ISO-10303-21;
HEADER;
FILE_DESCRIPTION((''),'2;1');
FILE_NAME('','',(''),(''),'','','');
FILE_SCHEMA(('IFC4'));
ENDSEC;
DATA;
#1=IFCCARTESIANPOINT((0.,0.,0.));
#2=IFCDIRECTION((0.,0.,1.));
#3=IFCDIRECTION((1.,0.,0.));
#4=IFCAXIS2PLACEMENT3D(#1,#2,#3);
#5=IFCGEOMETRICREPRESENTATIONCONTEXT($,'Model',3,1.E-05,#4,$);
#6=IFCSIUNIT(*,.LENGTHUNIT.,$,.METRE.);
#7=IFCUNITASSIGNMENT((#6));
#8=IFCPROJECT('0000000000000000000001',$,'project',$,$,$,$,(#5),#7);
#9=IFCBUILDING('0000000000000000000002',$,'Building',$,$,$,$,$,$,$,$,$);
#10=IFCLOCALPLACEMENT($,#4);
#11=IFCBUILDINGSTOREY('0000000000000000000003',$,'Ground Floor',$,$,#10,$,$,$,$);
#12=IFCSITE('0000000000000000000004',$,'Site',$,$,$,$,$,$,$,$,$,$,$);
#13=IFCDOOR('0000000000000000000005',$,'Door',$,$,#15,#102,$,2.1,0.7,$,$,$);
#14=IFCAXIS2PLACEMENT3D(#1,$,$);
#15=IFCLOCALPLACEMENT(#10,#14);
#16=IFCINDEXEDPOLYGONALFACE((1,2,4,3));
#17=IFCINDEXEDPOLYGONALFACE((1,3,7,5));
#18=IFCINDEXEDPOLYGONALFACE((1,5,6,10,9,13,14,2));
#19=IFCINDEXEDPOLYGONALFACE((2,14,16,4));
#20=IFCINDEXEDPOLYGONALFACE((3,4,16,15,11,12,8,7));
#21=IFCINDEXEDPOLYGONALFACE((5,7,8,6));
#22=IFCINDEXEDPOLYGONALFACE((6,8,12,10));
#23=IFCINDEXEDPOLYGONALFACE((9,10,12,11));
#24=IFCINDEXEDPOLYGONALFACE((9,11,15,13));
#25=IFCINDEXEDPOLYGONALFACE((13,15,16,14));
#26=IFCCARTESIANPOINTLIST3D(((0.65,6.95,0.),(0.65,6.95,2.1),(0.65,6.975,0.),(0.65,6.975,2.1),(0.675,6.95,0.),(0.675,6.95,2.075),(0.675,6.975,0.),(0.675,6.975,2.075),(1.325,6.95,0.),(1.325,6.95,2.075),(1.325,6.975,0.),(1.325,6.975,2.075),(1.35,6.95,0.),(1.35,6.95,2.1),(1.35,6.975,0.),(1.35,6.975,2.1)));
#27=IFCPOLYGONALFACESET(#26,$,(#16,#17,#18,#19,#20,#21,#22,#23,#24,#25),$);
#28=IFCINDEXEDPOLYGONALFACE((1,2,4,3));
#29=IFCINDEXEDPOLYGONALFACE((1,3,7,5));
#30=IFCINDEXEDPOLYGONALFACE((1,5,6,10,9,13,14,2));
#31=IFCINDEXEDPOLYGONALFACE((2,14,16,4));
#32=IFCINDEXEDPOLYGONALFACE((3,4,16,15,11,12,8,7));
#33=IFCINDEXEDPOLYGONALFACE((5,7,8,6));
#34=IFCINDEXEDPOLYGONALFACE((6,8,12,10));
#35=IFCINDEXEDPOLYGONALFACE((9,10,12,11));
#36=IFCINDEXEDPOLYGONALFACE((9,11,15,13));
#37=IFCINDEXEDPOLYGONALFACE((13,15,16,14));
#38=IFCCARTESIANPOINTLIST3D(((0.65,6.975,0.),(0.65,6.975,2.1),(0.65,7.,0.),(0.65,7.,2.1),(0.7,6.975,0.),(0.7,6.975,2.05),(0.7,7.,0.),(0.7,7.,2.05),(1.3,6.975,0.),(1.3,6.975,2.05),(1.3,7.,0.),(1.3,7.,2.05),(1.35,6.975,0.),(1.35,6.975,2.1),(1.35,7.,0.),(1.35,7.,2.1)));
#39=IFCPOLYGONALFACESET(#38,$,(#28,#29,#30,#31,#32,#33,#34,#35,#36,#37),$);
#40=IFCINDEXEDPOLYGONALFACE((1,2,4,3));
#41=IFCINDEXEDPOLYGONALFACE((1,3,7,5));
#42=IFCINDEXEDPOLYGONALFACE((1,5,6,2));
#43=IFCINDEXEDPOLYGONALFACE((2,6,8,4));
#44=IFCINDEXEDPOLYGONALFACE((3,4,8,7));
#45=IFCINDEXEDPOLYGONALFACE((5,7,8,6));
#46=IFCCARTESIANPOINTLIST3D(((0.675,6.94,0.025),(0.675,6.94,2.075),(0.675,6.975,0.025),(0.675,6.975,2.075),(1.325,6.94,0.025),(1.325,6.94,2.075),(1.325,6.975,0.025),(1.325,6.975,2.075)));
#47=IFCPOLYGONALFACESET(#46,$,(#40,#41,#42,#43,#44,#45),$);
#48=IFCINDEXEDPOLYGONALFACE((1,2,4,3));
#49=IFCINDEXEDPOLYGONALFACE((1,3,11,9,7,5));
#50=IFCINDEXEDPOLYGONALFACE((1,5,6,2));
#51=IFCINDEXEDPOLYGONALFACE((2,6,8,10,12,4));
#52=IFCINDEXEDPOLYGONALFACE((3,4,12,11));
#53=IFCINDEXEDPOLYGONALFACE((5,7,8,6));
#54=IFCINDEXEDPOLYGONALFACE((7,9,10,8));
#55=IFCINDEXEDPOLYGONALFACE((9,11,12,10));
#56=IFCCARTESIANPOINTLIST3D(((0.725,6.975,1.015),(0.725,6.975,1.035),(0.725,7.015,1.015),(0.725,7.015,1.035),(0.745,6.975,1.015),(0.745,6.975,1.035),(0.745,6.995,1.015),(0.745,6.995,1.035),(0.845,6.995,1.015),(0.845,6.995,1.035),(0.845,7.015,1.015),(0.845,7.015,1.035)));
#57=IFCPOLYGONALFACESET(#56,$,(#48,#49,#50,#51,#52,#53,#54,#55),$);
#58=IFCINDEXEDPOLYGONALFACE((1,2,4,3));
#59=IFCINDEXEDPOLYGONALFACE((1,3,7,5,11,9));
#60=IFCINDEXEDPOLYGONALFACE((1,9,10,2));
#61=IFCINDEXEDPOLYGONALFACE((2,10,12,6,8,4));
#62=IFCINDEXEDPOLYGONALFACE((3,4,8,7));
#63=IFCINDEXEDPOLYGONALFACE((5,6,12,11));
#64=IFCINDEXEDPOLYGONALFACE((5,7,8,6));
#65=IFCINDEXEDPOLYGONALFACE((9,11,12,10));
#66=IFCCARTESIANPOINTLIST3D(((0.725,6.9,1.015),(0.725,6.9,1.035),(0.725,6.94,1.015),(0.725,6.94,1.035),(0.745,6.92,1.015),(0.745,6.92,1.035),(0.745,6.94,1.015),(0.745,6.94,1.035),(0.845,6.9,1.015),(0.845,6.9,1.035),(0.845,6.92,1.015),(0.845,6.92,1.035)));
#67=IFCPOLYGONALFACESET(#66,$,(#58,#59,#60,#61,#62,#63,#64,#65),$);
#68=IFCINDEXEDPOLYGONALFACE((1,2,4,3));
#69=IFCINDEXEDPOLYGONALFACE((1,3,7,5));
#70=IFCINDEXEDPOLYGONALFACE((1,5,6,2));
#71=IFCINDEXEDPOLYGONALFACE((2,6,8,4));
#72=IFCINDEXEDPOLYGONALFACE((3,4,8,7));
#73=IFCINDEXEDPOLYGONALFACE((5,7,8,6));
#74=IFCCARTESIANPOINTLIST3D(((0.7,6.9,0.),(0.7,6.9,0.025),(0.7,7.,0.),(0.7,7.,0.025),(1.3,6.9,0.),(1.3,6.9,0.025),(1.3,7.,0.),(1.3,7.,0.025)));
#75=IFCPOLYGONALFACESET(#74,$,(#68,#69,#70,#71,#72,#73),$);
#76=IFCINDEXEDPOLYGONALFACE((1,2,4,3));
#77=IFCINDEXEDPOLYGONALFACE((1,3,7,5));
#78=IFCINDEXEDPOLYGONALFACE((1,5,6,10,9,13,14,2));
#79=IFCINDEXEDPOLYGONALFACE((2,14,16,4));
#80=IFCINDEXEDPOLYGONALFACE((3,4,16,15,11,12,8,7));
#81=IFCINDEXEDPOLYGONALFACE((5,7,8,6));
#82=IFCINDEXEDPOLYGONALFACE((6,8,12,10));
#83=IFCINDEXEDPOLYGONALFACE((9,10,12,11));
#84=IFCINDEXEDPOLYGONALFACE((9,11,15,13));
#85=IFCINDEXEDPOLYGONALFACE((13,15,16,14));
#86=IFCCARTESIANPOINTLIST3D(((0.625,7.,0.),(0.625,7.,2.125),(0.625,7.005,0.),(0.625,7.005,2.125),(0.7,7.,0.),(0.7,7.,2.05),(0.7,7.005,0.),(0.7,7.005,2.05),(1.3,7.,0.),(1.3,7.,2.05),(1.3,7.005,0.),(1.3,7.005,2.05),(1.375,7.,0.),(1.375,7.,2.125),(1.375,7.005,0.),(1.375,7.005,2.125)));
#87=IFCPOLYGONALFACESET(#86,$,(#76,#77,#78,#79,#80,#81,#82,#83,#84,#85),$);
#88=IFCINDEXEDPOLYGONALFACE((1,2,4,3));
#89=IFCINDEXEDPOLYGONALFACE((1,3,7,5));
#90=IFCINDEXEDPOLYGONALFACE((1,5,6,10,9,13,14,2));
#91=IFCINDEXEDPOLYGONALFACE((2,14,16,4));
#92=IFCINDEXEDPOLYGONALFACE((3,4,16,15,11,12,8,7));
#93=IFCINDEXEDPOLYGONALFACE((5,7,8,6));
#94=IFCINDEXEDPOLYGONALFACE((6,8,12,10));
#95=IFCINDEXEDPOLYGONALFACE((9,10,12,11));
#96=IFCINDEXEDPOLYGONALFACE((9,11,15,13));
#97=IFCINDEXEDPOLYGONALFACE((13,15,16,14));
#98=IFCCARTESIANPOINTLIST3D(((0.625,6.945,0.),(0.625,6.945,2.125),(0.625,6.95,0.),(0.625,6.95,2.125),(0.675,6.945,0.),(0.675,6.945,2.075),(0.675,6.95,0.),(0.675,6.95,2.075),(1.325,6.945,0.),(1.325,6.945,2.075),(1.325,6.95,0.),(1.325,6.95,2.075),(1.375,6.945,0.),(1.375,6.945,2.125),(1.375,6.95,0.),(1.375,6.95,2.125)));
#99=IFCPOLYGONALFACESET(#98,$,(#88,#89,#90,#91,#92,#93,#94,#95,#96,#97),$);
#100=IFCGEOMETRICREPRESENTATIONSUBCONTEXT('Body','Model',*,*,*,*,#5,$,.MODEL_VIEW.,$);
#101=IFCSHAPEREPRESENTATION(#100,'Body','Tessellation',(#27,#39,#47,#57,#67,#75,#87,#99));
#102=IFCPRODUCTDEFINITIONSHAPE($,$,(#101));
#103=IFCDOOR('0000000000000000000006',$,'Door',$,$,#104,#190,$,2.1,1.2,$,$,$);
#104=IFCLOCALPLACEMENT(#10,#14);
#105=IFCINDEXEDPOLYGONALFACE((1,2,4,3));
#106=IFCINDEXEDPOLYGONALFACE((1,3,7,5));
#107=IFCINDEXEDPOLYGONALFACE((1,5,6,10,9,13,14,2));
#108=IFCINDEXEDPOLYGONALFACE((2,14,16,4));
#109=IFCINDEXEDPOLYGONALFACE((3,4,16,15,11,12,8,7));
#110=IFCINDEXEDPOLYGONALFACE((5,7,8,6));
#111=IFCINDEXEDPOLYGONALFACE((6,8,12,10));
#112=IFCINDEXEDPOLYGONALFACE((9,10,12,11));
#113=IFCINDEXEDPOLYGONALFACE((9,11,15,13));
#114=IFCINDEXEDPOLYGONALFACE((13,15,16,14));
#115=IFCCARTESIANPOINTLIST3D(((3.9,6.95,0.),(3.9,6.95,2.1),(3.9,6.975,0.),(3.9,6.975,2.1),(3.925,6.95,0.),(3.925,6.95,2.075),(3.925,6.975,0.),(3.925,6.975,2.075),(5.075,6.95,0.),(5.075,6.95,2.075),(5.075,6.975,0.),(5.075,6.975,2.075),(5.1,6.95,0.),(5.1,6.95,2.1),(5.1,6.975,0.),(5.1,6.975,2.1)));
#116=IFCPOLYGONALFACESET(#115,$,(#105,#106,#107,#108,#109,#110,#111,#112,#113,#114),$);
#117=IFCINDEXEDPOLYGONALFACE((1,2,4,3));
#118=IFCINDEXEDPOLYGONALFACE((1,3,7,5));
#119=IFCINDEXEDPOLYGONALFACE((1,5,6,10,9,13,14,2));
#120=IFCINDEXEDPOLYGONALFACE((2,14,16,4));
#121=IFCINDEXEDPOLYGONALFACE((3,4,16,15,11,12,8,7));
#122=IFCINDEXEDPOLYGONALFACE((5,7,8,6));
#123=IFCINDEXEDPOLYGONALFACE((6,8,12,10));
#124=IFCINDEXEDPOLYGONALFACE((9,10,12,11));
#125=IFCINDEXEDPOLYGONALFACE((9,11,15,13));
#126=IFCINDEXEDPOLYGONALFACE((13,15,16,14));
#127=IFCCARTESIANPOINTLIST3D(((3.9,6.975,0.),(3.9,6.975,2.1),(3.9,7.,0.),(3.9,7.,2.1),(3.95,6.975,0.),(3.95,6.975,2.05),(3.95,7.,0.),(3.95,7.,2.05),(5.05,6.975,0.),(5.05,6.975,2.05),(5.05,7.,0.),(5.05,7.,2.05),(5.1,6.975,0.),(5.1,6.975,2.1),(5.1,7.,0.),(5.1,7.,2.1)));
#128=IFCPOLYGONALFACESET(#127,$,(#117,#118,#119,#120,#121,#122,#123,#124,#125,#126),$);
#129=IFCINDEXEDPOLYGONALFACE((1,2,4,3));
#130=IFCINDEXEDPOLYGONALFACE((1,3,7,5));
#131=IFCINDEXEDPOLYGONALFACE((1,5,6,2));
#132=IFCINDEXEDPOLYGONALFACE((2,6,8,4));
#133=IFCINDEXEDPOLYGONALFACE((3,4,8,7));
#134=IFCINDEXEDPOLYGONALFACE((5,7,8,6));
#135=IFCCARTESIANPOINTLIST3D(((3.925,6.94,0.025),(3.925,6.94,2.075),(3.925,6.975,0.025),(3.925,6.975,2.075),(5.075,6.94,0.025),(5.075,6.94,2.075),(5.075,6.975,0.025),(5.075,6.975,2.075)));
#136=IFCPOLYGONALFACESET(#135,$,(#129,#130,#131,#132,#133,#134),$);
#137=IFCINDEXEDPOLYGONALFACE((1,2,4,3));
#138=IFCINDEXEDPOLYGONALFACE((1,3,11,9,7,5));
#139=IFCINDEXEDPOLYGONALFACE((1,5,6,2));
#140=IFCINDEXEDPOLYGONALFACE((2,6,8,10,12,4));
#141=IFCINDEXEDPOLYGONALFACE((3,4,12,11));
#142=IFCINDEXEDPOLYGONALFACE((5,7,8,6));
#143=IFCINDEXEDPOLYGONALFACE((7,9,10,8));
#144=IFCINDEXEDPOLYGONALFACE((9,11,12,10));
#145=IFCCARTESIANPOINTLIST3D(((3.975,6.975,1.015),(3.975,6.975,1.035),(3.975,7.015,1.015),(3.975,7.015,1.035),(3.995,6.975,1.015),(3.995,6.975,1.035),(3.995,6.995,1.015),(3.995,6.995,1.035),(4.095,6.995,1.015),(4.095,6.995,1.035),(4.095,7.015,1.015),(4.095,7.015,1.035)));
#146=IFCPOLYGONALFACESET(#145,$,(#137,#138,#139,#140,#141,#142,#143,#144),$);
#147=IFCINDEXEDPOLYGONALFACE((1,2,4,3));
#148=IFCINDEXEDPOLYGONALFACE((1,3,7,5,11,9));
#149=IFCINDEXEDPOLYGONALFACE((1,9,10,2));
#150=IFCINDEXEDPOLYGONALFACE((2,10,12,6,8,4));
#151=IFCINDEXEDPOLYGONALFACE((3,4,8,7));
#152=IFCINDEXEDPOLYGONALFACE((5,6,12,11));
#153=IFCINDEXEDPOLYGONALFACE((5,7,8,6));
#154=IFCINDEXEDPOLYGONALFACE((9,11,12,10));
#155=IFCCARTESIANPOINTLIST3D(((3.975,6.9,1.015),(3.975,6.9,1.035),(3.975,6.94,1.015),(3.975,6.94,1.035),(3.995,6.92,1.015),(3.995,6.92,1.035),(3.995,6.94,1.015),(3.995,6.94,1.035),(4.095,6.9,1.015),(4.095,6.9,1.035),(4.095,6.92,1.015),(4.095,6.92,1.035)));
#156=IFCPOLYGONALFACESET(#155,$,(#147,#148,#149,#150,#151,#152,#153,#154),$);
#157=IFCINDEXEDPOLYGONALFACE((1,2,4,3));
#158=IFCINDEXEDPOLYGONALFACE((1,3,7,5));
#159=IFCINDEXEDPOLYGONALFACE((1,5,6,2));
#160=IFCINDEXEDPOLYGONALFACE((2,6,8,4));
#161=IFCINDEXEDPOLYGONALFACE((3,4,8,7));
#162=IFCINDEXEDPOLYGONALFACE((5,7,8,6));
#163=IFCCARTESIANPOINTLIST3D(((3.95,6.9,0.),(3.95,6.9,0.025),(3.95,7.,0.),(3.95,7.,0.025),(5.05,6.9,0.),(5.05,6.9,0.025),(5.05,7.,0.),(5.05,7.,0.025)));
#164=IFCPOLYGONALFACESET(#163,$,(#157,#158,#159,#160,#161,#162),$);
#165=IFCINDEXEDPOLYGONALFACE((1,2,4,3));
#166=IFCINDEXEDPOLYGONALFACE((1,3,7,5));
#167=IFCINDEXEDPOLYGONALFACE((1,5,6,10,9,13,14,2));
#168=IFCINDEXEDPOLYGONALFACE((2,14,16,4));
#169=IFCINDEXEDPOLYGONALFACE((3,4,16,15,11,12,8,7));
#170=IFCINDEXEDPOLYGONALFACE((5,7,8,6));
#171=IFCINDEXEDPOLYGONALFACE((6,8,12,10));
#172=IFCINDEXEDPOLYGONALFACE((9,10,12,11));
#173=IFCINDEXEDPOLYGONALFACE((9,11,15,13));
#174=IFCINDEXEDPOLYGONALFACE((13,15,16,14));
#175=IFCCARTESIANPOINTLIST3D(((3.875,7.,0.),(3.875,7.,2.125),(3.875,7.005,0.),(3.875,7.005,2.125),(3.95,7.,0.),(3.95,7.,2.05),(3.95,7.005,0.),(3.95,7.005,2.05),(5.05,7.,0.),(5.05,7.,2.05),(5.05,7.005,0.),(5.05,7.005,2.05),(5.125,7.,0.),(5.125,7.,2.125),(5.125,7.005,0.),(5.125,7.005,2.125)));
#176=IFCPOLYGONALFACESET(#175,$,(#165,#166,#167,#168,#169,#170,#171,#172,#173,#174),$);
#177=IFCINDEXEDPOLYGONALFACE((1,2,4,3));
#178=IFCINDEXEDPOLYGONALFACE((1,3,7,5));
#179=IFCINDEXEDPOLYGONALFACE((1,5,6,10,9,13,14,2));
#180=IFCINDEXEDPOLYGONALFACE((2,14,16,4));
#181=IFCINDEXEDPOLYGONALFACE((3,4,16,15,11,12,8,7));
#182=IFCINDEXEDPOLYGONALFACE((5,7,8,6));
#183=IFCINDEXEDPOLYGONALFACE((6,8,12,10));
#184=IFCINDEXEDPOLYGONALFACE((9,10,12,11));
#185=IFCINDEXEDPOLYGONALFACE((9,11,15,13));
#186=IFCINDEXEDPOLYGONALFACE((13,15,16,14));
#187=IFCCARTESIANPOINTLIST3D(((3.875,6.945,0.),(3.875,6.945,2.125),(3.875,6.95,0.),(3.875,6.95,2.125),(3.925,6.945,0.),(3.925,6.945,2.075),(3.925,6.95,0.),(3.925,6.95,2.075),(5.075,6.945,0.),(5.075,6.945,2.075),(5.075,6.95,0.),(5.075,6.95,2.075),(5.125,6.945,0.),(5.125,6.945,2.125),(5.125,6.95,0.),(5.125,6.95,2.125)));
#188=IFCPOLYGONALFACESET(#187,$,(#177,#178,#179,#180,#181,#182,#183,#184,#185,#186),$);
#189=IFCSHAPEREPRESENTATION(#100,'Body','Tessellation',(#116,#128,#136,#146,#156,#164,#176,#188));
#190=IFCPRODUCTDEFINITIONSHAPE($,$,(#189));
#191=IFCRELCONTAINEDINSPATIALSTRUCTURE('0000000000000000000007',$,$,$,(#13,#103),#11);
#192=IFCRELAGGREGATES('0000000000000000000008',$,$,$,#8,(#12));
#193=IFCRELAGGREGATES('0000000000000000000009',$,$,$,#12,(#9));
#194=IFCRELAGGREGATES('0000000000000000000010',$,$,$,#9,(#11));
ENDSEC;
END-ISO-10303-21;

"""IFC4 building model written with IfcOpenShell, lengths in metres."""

from ifc_helpers import new_model, si_unit, frame, origin_with_axes, place, context, subcontext, project, spatial, line, indexed_curve, outline, extrude, element, save


model = new_model("IFC4")

# Units and contexts
model_context = context("Model", 3, precision=1e-05, world=origin_with_axes())
body_context = subcontext(model_context, "Body", "Model", "MODEL_VIEW")
ifc_project = project(units=[si_unit("LENGTHUNIT", "METRE")], contexts=[model_context])

# Site, building, storey
site = spatial("IfcSite", under=ifc_project, Name="Site")
building = spatial("IfcBuilding", under=site, Name="Building")
storey_placement = place(None, origin_with_axes())
storey = spatial("IfcBuildingStorey", under=building, at=storey_placement, Name="Ground Floor")

# Doors
door_1_placement = place(storey_placement, frame((1.35, 7.0, 0.0), z_axis=(0.0, 0.0, 1.0), x_axis=(-1.0, 0.0, 0.0)))
element("IfcDoor", 1, at=door_1_placement, inside=storey, Name="Door", OverallHeight=2.1, OverallWidth=0.7, context=body_context, shape_type="SweptSolid", body=[
    extrude(outline(indexed_curve([(0.0, 0.0), (0.0, 2.1), (0.7, 2.1), (0.7, 0.0), (0.675, 0.0), (0.675, 2.075), (0.025, 2.075), (0.025, 0.0)], segments=[line(1, 2, 3, 4, 5, 6, 7, 8, 1)])), frame((0.0, 0.025, 0.0), z_axis=(0.0, -1.0, 0.0), x_axis=(1.0, 0.0, 0.0)), (0.0, 0.0, -1.0), 0.025),
    extrude(outline(indexed_curve([(0.0, 0.0), (0.0, 2.1), (0.7, 2.1), (0.7, 0.0), (0.65, 0.0), (0.65, 2.05), (0.05, 2.05), (0.05, 0.0)], segments=[line(1, 2, 3, 4, 5, 6, 7, 8, 1)])), frame((0.0, 0.0, 0.0), z_axis=(0.0, -1.0, 0.0), x_axis=(1.0, 0.0, 0.0)), (0.0, 0.0, -1.0), 0.025),
    extrude(outline(indexed_curve([(0.0, 0.0), (0.65, 0.0), (0.65, 0.035), (0.0, 0.035)], segments=[line(1, 2, 3, 4, 1)])), frame((0.025, 0.025, 0.025), z_axis=(0.0, 0.0, 1.0), x_axis=(1.0, 0.0, 0.0)), (0.0, 0.0, 1.0), 2.05),
    extrude(outline(indexed_curve([(0.0, 0.0), (0.0, -0.04), (-0.12, -0.04), (-0.12, -0.02), (-0.02, -0.02), (-0.02, 0.0)], segments=[line(1, 2, 3, 4, 5, 6, 1)])), frame((0.625, 0.025, 1.015), z_axis=(0.0, 0.0, 1.0), x_axis=(1.0, 0.0, 0.0)), (0.0, 0.0, 1.0), 0.02),
    extrude(outline(indexed_curve([(0.0, 0.0), (0.0, 0.04), (-0.12, 0.04), (-0.12, 0.02), (-0.02, 0.02), (-0.02, 0.0)], segments=[line(1, 2, 3, 4, 5, 6, 1)])), frame((0.625, 0.06, 1.015), z_axis=(0.0, 0.0, 1.0), x_axis=(1.0, 0.0, 0.0)), (0.0, 0.0, 1.0), 0.02),
    extrude(outline(indexed_curve([(0.0, 0.0), (0.6, 0.0), (0.6, 0.1), (0.0, 0.1)], segments=[line(1, 2, 3, 4, 1)])), frame((0.05, 0.0, 0.0), z_axis=(0.0, 0.0, 1.0), x_axis=(1.0, 0.0, 0.0)), (0.0, 0.0, 1.0), 0.025),
    extrude(outline(indexed_curve([(0.0, 0.0), (0.0, 2.125), (0.75, 2.125), (0.75, 0.0), (0.675, 0.0), (0.675, 2.05), (0.075, 2.05), (0.075, 0.0)], segments=[line(1, 2, 3, 4, 5, 6, 7, 8, 1)])), frame((-0.025, -0.005, 0.0), z_axis=(0.0, -1.0, 0.0), x_axis=(1.0, 0.0, 0.0)), (0.0, 0.0, -1.0), 0.005),
    extrude(outline(indexed_curve([(0.0, 0.0), (0.0, 2.125), (0.75, 2.125), (0.75, 0.0), (0.7, 0.0), (0.7, 2.075), (0.05, 2.075), (0.05, 0.0)], segments=[line(1, 2, 3, 4, 5, 6, 7, 8, 1)])), frame((-0.025, 0.05, 0.0), z_axis=(0.0, -1.0, 0.0), x_axis=(1.0, 0.0, 0.0)), (0.0, 0.0, -1.0), 0.005),
])
door_2_placement = place(storey_placement, frame((5.1, 7.0, 0.0), z_axis=(0.0, 0.0, 1.0), x_axis=(-1.0, 0.0, 0.0)))
element("IfcDoor", 2, at=door_2_placement, inside=storey, Name="Door", OverallHeight=2.1, OverallWidth=1.2, context=body_context, shape_type="SweptSolid", body=[
    extrude(outline(indexed_curve([(0.0, 0.0), (0.0, 2.1), (1.2, 2.1), (1.2, 0.0), (1.175, 0.0), (1.175, 2.075), (0.025, 2.075), (0.025, 0.0)], segments=[line(1, 2, 3, 4, 5, 6, 7, 8, 1)])), frame((0.0, 0.025, 0.0), z_axis=(0.0, -1.0, 0.0), x_axis=(1.0, 0.0, 0.0)), (0.0, 0.0, -1.0), 0.025),
    extrude(outline(indexed_curve([(0.0, 0.0), (0.0, 2.1), (1.2, 2.1), (1.2, 0.0), (1.15, 0.0), (1.15, 2.05), (0.05, 2.05), (0.05, 0.0)], segments=[line(1, 2, 3, 4, 5, 6, 7, 8, 1)])), frame((0.0, 0.0, 0.0), z_axis=(0.0, -1.0, 0.0), x_axis=(1.0, 0.0, 0.0)), (0.0, 0.0, -1.0), 0.025),
    extrude(outline(indexed_curve([(0.0, 0.0), (1.15, 0.0), (1.15, 0.035), (0.0, 0.035)], segments=[line(1, 2, 3, 4, 1)])), frame((0.025, 0.025, 0.025), z_axis=(0.0, 0.0, 1.0), x_axis=(1.0, 0.0, 0.0)), (0.0, 0.0, 1.0), 2.05),
    extrude(outline(indexed_curve([(0.0, 0.0), (0.0, -0.04), (-0.12, -0.04), (-0.12, -0.02), (-0.02, -0.02), (-0.02, 0.0)], segments=[line(1, 2, 3, 4, 5, 6, 1)])), frame((1.125, 0.025, 1.015), z_axis=(0.0, 0.0, 1.0), x_axis=(1.0, 0.0, 0.0)), (0.0, 0.0, 1.0), 0.02),
    extrude(outline(indexed_curve([(0.0, 0.0), (0.0, 0.04), (-0.12, 0.04), (-0.12, 0.02), (-0.02, 0.02), (-0.02, 0.0)], segments=[line(1, 2, 3, 4, 5, 6, 1)])), frame((1.125, 0.06, 1.015), z_axis=(0.0, 0.0, 1.0), x_axis=(1.0, 0.0, 0.0)), (0.0, 0.0, 1.0), 0.02),
    extrude(outline(indexed_curve([(0.0, 0.0), (1.1, 0.0), (1.1, 0.1), (0.0, 0.1)], segments=[line(1, 2, 3, 4, 1)])), frame((0.05, 0.0, 0.0), z_axis=(0.0, 0.0, 1.0), x_axis=(1.0, 0.0, 0.0)), (0.0, 0.0, 1.0), 0.025),
    extrude(outline(indexed_curve([(0.0, 0.0), (0.0, 2.125), (1.25, 2.125), (1.25, 0.0), (1.175, 0.0), (1.175, 2.05), (0.075, 2.05), (0.075, 0.0)], segments=[line(1, 2, 3, 4, 5, 6, 7, 8, 1)])), frame((-0.025, -0.005, 0.0), z_axis=(0.0, -1.0, 0.0), x_axis=(1.0, 0.0, 0.0)), (0.0, 0.0, -1.0), 0.005),
    extrude(outline(indexed_curve([(0.0, 0.0), (0.0, 2.125), (1.25, 2.125), (1.25, 0.0), (1.2, 0.0), (1.2, 2.075), (0.05, 2.075), (0.05, 0.0)], segments=[line(1, 2, 3, 4, 5, 6, 7, 8, 1)])), frame((-0.025, 0.05, 0.0), z_axis=(0.0, -1.0, 0.0), x_axis=(1.0, 0.0, 0.0)), (0.0, 0.0, -1.0), 0.005),
])

save(model, "model.ifc")
